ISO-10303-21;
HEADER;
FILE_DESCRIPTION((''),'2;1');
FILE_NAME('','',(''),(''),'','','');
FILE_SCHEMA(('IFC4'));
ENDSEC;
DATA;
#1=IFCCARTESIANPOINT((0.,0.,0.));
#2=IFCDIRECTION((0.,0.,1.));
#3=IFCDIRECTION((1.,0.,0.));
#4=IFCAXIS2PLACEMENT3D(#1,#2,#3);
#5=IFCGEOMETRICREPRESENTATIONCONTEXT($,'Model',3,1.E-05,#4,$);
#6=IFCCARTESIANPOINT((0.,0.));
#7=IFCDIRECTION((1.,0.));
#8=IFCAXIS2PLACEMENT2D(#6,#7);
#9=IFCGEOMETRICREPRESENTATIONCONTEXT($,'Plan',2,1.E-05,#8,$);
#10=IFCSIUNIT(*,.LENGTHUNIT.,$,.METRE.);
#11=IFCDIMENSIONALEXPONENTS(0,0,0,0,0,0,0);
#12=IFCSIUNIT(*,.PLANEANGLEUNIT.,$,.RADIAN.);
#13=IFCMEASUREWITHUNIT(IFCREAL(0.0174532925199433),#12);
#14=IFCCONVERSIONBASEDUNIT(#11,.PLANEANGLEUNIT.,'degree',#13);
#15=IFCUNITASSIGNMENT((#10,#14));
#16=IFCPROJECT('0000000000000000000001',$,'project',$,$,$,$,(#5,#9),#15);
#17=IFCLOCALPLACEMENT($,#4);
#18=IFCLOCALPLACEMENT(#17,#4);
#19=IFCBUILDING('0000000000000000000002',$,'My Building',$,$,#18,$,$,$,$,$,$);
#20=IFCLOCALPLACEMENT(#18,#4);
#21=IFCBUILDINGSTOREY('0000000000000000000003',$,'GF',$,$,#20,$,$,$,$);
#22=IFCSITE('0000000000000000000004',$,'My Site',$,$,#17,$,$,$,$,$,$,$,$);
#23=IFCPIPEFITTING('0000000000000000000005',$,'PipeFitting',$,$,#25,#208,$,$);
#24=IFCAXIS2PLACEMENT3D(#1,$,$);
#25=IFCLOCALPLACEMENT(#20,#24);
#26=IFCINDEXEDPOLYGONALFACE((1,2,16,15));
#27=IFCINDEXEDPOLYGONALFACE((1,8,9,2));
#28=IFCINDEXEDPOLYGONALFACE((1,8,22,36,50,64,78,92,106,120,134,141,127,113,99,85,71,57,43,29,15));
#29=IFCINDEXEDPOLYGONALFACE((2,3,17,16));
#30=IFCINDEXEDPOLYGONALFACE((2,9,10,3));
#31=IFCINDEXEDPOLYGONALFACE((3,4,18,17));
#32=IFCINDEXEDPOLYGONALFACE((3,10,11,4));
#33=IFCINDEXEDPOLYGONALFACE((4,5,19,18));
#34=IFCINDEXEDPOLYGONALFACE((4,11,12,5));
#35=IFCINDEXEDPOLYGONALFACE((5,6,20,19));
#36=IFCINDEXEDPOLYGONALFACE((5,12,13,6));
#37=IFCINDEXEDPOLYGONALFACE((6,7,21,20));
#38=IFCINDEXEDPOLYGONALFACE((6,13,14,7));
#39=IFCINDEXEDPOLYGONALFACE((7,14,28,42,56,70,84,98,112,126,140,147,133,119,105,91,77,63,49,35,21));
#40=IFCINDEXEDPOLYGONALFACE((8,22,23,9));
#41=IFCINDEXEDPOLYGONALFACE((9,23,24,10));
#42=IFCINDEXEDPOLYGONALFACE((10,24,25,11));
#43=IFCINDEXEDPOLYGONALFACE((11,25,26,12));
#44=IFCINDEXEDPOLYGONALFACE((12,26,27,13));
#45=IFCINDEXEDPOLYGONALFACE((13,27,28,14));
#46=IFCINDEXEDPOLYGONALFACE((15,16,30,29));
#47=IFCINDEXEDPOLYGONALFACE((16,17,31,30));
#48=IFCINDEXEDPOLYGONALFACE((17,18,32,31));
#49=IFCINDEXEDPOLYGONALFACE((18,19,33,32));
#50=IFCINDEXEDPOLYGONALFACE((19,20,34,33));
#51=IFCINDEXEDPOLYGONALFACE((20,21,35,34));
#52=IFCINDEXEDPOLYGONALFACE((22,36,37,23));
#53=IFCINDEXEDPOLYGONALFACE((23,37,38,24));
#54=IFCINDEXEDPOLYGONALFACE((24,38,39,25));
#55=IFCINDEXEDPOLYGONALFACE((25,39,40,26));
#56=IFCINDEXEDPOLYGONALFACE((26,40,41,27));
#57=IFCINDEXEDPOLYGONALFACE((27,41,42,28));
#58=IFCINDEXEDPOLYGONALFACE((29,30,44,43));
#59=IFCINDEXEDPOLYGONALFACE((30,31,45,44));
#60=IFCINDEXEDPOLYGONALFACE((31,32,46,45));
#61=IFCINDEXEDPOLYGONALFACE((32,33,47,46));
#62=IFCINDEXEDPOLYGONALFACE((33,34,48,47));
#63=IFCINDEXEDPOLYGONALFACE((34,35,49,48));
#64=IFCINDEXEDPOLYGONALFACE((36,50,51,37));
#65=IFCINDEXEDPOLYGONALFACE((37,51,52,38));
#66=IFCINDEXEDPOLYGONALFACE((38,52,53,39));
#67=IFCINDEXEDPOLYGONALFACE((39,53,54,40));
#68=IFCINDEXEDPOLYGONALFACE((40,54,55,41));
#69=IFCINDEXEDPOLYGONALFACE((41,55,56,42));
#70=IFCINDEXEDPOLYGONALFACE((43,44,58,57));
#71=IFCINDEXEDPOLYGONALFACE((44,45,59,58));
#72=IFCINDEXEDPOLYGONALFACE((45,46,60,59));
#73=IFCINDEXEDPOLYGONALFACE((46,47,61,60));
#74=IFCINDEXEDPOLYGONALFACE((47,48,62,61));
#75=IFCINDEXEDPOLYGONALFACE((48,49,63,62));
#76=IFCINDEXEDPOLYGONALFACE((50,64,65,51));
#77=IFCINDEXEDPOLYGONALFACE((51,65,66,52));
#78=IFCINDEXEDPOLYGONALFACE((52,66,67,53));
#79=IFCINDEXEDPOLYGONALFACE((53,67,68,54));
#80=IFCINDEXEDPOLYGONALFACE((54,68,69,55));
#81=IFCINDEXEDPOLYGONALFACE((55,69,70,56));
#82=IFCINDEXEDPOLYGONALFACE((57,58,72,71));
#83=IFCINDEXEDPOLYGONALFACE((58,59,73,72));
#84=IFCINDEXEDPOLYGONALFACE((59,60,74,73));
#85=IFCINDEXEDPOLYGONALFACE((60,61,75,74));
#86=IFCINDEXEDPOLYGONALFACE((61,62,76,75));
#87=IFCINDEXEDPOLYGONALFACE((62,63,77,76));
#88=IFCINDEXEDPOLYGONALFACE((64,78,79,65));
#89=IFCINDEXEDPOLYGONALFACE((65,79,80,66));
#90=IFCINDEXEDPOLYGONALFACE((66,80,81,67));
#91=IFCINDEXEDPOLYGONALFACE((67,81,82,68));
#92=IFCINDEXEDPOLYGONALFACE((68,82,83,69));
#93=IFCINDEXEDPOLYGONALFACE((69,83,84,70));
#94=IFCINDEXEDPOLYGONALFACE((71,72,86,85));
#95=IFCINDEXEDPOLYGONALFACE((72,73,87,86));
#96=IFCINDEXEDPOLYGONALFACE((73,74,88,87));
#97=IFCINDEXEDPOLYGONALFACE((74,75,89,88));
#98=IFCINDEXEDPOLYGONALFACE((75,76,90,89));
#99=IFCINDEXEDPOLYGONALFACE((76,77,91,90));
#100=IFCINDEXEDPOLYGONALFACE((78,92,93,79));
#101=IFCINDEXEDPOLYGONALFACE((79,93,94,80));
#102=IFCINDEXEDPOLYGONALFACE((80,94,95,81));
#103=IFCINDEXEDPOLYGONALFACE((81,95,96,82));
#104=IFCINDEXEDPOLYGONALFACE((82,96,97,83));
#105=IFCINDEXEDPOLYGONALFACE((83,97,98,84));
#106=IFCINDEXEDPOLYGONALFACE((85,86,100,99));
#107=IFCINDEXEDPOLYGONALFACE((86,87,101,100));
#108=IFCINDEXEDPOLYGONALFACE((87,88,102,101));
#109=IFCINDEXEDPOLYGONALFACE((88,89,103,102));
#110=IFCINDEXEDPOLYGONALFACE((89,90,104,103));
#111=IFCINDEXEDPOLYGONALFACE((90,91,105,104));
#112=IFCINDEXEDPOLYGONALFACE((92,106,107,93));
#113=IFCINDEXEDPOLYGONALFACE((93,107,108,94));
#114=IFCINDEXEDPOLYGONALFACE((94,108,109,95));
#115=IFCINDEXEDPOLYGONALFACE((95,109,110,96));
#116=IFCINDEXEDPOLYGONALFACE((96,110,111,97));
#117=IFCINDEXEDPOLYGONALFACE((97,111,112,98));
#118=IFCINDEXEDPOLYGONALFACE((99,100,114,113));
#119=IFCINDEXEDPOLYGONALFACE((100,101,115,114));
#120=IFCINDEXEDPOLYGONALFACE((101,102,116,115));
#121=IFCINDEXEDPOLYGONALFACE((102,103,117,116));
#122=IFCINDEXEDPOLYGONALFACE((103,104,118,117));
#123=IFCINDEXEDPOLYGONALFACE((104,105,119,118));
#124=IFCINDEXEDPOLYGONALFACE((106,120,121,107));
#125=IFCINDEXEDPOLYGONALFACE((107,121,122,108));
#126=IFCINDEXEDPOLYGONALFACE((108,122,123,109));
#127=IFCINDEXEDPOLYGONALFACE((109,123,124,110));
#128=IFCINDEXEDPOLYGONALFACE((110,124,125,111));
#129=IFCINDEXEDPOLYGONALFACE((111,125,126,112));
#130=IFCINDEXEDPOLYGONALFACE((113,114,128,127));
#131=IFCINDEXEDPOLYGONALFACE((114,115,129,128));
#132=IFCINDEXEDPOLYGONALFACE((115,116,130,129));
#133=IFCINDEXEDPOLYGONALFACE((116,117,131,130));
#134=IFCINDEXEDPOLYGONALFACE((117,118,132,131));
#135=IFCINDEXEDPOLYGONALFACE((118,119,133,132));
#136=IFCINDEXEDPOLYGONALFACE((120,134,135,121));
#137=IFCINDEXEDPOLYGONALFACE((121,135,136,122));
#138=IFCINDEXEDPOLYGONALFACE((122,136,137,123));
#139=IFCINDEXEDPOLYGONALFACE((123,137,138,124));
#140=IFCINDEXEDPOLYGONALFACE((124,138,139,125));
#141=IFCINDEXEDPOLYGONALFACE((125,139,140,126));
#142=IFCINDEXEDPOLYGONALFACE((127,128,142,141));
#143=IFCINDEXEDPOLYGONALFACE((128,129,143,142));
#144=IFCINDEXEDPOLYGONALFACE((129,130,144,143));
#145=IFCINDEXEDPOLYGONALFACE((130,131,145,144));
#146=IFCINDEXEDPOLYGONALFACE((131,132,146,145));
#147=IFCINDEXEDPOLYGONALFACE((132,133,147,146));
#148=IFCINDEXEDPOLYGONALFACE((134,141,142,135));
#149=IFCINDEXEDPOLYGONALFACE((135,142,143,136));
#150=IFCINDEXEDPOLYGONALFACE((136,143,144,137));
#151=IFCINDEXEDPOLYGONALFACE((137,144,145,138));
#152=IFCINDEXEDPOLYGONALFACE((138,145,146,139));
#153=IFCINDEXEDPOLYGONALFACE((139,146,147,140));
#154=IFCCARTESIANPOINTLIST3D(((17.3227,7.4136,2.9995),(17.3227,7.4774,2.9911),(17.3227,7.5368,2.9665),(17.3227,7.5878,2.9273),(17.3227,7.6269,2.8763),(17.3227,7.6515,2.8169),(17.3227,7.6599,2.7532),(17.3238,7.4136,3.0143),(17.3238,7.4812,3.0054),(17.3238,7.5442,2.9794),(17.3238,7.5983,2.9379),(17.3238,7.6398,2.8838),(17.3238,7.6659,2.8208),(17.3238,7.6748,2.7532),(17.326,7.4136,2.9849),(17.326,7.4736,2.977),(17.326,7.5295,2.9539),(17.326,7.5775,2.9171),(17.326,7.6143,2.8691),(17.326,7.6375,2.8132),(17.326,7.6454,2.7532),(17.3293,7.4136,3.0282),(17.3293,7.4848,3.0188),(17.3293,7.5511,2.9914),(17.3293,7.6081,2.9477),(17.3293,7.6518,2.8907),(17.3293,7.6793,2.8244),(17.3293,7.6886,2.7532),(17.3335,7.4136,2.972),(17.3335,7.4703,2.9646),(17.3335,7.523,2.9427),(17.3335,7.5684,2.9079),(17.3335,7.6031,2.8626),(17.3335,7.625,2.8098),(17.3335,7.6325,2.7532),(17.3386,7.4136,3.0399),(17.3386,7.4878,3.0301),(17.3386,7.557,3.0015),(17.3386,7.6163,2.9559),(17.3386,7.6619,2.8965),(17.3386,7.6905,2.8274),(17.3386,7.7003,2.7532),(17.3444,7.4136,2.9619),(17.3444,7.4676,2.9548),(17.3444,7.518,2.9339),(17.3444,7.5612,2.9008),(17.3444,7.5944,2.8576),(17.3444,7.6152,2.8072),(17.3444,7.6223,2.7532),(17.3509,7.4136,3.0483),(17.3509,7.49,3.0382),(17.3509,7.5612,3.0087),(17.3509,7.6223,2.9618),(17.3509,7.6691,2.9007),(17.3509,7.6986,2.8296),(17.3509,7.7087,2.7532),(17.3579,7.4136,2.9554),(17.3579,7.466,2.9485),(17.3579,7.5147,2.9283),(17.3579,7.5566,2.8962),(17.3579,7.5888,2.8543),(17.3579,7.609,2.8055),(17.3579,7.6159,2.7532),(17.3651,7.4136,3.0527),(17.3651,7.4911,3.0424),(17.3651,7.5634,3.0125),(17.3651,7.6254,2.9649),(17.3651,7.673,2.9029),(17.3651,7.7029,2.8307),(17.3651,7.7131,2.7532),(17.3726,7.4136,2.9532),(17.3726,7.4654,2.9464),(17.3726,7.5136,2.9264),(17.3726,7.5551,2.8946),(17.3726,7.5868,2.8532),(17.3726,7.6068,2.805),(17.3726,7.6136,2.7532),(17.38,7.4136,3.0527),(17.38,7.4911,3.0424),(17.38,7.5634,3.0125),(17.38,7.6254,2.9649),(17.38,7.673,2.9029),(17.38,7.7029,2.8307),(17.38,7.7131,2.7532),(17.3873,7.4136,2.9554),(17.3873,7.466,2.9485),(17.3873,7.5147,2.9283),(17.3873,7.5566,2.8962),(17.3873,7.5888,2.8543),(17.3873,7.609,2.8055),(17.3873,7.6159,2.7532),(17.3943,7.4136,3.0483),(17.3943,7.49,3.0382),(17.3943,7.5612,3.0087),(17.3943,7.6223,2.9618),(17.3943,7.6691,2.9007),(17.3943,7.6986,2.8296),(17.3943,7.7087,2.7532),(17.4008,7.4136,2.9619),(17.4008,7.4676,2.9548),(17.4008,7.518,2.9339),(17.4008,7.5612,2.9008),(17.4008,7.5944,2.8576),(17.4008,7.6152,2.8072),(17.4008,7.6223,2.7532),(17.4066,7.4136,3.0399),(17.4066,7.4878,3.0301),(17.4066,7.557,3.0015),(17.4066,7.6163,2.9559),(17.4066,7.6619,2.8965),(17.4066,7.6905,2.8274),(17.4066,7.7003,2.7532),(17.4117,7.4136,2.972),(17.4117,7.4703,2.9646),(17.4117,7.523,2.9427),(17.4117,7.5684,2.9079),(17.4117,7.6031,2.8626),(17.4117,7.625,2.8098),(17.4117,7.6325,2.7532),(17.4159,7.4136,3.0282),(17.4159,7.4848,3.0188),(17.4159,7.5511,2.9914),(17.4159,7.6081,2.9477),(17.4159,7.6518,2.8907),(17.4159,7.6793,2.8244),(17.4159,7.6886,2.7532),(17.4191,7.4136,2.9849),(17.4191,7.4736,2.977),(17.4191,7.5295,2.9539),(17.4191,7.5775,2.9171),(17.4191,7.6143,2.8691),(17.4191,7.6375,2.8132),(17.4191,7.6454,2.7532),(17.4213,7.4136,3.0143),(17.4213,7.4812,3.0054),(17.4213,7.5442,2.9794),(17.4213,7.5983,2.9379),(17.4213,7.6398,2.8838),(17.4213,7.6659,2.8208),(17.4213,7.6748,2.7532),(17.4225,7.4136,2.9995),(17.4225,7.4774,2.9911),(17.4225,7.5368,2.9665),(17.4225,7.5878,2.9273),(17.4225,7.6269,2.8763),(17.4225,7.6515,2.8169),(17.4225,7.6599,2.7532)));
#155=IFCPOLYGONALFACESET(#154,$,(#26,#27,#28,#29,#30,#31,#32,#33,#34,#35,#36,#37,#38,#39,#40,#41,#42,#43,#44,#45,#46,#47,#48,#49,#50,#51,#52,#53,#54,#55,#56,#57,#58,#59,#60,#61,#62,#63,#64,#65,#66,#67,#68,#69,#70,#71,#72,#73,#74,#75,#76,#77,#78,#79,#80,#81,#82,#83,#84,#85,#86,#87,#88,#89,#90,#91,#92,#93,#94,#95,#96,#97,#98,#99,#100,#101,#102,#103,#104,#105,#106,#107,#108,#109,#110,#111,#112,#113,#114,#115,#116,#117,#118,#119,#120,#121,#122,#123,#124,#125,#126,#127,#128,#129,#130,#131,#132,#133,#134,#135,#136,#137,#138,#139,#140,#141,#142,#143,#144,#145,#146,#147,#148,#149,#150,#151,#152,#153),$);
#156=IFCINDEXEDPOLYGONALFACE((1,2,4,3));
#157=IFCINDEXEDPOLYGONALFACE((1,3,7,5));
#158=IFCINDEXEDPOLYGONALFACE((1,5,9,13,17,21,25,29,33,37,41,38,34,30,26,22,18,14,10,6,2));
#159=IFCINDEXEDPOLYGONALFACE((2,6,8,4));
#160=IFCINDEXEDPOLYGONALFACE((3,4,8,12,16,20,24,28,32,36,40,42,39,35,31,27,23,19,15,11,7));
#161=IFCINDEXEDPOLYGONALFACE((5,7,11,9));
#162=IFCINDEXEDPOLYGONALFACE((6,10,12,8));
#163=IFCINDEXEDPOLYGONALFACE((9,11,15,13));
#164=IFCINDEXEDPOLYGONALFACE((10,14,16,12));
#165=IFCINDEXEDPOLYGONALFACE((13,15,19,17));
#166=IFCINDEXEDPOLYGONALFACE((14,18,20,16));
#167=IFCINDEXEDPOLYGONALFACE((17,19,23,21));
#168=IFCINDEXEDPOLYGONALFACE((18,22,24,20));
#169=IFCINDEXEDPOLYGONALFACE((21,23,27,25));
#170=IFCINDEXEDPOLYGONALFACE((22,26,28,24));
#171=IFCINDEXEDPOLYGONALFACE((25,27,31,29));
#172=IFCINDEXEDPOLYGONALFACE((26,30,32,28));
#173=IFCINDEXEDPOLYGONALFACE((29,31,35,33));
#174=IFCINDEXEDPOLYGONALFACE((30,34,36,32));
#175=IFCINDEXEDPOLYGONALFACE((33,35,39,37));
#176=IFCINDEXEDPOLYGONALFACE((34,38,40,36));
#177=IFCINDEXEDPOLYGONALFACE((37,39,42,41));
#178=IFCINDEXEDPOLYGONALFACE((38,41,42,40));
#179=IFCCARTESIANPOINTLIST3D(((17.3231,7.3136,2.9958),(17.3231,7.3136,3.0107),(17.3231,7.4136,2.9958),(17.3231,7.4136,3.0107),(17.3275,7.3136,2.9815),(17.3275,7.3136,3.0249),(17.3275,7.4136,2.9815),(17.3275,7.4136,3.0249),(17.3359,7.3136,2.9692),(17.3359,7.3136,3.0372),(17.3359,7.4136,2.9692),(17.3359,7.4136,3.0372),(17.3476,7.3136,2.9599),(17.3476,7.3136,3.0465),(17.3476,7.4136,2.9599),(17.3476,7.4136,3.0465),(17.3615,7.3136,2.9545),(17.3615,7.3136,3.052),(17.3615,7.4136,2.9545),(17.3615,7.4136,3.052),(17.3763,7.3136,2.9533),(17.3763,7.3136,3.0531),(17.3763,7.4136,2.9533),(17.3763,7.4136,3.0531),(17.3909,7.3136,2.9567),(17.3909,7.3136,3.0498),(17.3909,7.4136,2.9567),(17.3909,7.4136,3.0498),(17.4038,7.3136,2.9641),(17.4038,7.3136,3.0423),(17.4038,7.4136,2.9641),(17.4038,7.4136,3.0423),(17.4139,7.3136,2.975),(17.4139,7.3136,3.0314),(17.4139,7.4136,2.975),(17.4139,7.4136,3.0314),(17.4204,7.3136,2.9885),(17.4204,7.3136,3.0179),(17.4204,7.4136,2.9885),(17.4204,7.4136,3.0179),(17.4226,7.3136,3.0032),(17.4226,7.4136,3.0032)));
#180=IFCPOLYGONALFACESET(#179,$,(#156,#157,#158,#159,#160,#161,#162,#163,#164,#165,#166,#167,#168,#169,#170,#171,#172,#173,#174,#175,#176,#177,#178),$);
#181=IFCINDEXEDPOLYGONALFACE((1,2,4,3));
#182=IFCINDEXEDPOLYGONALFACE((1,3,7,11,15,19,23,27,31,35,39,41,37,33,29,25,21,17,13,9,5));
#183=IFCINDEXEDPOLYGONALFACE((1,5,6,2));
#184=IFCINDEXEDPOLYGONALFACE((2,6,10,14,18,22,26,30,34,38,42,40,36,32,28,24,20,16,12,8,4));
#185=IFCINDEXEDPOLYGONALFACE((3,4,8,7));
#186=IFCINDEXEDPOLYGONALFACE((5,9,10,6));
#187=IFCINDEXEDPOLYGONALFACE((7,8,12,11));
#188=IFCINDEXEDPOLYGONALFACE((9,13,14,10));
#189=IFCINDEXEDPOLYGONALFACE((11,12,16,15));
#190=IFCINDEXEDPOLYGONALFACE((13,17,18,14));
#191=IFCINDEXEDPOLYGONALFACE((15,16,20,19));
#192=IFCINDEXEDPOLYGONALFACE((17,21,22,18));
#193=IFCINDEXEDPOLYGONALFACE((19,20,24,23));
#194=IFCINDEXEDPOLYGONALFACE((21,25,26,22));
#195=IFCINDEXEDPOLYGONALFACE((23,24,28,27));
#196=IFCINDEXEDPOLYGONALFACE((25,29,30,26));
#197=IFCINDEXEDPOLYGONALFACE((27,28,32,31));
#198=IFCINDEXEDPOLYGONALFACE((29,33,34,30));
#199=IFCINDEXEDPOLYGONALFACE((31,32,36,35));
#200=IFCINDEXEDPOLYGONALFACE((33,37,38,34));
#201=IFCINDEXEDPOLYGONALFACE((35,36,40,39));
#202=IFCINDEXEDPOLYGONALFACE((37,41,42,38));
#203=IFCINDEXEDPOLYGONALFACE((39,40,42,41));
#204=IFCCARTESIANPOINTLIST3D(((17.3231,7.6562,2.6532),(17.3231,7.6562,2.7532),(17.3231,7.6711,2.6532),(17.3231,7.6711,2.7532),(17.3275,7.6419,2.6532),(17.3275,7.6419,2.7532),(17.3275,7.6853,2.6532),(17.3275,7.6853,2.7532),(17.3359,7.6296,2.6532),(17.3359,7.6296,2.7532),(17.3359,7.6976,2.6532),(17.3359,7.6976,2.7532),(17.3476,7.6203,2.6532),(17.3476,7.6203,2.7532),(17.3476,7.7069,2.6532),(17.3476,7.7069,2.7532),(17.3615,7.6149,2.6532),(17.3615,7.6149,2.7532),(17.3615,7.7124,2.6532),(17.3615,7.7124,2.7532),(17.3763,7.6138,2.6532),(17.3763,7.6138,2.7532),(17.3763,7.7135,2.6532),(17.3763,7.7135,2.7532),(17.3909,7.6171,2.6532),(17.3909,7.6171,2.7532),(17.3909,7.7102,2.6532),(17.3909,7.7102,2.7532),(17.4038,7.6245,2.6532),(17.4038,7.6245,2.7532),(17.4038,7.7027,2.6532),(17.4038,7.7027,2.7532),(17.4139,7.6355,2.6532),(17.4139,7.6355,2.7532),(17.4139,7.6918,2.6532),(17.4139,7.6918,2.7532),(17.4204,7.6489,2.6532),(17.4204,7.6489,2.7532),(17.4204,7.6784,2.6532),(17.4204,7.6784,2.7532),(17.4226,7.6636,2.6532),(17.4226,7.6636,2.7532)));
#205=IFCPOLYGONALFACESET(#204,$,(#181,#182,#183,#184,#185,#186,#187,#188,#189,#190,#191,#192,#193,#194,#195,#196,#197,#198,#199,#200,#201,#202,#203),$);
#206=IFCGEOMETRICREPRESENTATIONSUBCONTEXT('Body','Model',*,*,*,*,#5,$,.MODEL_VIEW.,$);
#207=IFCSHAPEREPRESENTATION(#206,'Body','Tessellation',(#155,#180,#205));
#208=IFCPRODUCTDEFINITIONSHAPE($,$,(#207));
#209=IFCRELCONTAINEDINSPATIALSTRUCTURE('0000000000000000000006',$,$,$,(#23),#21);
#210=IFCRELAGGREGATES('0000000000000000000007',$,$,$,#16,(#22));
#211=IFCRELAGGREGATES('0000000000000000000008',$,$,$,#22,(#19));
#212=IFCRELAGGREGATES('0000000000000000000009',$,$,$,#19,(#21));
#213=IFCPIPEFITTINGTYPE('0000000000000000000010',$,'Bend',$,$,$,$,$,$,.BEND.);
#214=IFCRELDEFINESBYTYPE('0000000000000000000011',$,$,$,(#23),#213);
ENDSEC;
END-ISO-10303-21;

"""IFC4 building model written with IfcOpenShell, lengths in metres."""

from ifc_helpers import new_model, entity, si_unit, converted_unit, frame, origin_with_axes, origin_2d_with_axis, place, context, subcontext, project, spatial, circle, extrude, source, transform, mapped, type_object, type_shapes, element, save


model = new_model("IFC4")

# Units and contexts
model_context = context("Model", 3, precision=1e-05, world=origin_with_axes())
plan_context = context("Plan", 2, precision=1e-05, world=origin_2d_with_axis())
body_context_1 = subcontext(model_context, "Body", "Model", "MODEL_VIEW")
ifc_project = project(units=[si_unit("LENGTHUNIT", "METRE"), converted_unit("PLANEANGLEUNIT", "degree", entity("IfcReal", 0.0174532925199433), si_unit("PLANEANGLEUNIT", "RADIAN"), dimensions=[0, 0, 0, 0, 0, 0, 0])], contexts=[model_context, plan_context])

# Site, building, storey
site_placement = place(None, origin_with_axes())
site = spatial("IfcSite", under=ifc_project, at=site_placement, Name="My Site")
building_placement = place(site_placement, origin_with_axes())
building = spatial("IfcBuilding", under=site, at=building_placement, Name="My Building")
storey_placement = place(building_placement, origin_with_axes())
storey = spatial("IfcBuildingStorey", under=building, at=storey_placement, Name="GF")

# Pipe fitting
pipe_fitting_type = type_object("IfcPipeFittingType", Name="Bend", PredefinedType="BEND")
shared_shape_1 = source(origin_with_axes(), body_context_1, "Body", "SolidModel", [
    entity("IfcSweptDiskSolid", entity("IfcIndexedPolyCurve", entity("IfcCartesianPointList3D", [[0.0, 0.0, -0.1], [0.0, -0.0732, -0.2768], [0.0, -0.25, -0.35]]), [entity("IfcArcIndex", [1, 2, 3])]), 0.05),
    extrude(circle(Radius=0.05), origin_with_axes(), (0.0, 0.0, -1.0), 0.1),
    extrude(circle(Radius=0.05), frame((0.0, -0.25, -0.35), z_axis=(0.0, -1.0, 0.0), x_axis=(1.0, 0.0, 0.0)), (0.0, 0.0, 1.0), 0.1),
])
type_shapes(pipe_fitting_type, [shared_shape_1])
for number, where, z_axis, x_axis, name in (
    (1, (17.3726, 7.3136, 3.0032), (0.0, -1.0, 0.0), (1.0, 0.0, 0.0), "PipeFitting"),
):
    element("IfcPipeFitting", number, at=place(storey_placement, frame(where, z_axis=z_axis, x_axis=x_axis)), inside=storey, type_object=pipe_fitting_type, Name=name, context=body_context_1, shape_type="MappedRepresentation", body=[
        mapped(shared_shape_1, transform((0.0, 0.0, 0.0), x_axis=(1.0, 0.0, 0.0), y_axis=(0.0, 1.0, 0.0), z_axis=(0.0, 0.0, 1.0), scale=1.0)),
    ])

save(model, "model.ifc")
